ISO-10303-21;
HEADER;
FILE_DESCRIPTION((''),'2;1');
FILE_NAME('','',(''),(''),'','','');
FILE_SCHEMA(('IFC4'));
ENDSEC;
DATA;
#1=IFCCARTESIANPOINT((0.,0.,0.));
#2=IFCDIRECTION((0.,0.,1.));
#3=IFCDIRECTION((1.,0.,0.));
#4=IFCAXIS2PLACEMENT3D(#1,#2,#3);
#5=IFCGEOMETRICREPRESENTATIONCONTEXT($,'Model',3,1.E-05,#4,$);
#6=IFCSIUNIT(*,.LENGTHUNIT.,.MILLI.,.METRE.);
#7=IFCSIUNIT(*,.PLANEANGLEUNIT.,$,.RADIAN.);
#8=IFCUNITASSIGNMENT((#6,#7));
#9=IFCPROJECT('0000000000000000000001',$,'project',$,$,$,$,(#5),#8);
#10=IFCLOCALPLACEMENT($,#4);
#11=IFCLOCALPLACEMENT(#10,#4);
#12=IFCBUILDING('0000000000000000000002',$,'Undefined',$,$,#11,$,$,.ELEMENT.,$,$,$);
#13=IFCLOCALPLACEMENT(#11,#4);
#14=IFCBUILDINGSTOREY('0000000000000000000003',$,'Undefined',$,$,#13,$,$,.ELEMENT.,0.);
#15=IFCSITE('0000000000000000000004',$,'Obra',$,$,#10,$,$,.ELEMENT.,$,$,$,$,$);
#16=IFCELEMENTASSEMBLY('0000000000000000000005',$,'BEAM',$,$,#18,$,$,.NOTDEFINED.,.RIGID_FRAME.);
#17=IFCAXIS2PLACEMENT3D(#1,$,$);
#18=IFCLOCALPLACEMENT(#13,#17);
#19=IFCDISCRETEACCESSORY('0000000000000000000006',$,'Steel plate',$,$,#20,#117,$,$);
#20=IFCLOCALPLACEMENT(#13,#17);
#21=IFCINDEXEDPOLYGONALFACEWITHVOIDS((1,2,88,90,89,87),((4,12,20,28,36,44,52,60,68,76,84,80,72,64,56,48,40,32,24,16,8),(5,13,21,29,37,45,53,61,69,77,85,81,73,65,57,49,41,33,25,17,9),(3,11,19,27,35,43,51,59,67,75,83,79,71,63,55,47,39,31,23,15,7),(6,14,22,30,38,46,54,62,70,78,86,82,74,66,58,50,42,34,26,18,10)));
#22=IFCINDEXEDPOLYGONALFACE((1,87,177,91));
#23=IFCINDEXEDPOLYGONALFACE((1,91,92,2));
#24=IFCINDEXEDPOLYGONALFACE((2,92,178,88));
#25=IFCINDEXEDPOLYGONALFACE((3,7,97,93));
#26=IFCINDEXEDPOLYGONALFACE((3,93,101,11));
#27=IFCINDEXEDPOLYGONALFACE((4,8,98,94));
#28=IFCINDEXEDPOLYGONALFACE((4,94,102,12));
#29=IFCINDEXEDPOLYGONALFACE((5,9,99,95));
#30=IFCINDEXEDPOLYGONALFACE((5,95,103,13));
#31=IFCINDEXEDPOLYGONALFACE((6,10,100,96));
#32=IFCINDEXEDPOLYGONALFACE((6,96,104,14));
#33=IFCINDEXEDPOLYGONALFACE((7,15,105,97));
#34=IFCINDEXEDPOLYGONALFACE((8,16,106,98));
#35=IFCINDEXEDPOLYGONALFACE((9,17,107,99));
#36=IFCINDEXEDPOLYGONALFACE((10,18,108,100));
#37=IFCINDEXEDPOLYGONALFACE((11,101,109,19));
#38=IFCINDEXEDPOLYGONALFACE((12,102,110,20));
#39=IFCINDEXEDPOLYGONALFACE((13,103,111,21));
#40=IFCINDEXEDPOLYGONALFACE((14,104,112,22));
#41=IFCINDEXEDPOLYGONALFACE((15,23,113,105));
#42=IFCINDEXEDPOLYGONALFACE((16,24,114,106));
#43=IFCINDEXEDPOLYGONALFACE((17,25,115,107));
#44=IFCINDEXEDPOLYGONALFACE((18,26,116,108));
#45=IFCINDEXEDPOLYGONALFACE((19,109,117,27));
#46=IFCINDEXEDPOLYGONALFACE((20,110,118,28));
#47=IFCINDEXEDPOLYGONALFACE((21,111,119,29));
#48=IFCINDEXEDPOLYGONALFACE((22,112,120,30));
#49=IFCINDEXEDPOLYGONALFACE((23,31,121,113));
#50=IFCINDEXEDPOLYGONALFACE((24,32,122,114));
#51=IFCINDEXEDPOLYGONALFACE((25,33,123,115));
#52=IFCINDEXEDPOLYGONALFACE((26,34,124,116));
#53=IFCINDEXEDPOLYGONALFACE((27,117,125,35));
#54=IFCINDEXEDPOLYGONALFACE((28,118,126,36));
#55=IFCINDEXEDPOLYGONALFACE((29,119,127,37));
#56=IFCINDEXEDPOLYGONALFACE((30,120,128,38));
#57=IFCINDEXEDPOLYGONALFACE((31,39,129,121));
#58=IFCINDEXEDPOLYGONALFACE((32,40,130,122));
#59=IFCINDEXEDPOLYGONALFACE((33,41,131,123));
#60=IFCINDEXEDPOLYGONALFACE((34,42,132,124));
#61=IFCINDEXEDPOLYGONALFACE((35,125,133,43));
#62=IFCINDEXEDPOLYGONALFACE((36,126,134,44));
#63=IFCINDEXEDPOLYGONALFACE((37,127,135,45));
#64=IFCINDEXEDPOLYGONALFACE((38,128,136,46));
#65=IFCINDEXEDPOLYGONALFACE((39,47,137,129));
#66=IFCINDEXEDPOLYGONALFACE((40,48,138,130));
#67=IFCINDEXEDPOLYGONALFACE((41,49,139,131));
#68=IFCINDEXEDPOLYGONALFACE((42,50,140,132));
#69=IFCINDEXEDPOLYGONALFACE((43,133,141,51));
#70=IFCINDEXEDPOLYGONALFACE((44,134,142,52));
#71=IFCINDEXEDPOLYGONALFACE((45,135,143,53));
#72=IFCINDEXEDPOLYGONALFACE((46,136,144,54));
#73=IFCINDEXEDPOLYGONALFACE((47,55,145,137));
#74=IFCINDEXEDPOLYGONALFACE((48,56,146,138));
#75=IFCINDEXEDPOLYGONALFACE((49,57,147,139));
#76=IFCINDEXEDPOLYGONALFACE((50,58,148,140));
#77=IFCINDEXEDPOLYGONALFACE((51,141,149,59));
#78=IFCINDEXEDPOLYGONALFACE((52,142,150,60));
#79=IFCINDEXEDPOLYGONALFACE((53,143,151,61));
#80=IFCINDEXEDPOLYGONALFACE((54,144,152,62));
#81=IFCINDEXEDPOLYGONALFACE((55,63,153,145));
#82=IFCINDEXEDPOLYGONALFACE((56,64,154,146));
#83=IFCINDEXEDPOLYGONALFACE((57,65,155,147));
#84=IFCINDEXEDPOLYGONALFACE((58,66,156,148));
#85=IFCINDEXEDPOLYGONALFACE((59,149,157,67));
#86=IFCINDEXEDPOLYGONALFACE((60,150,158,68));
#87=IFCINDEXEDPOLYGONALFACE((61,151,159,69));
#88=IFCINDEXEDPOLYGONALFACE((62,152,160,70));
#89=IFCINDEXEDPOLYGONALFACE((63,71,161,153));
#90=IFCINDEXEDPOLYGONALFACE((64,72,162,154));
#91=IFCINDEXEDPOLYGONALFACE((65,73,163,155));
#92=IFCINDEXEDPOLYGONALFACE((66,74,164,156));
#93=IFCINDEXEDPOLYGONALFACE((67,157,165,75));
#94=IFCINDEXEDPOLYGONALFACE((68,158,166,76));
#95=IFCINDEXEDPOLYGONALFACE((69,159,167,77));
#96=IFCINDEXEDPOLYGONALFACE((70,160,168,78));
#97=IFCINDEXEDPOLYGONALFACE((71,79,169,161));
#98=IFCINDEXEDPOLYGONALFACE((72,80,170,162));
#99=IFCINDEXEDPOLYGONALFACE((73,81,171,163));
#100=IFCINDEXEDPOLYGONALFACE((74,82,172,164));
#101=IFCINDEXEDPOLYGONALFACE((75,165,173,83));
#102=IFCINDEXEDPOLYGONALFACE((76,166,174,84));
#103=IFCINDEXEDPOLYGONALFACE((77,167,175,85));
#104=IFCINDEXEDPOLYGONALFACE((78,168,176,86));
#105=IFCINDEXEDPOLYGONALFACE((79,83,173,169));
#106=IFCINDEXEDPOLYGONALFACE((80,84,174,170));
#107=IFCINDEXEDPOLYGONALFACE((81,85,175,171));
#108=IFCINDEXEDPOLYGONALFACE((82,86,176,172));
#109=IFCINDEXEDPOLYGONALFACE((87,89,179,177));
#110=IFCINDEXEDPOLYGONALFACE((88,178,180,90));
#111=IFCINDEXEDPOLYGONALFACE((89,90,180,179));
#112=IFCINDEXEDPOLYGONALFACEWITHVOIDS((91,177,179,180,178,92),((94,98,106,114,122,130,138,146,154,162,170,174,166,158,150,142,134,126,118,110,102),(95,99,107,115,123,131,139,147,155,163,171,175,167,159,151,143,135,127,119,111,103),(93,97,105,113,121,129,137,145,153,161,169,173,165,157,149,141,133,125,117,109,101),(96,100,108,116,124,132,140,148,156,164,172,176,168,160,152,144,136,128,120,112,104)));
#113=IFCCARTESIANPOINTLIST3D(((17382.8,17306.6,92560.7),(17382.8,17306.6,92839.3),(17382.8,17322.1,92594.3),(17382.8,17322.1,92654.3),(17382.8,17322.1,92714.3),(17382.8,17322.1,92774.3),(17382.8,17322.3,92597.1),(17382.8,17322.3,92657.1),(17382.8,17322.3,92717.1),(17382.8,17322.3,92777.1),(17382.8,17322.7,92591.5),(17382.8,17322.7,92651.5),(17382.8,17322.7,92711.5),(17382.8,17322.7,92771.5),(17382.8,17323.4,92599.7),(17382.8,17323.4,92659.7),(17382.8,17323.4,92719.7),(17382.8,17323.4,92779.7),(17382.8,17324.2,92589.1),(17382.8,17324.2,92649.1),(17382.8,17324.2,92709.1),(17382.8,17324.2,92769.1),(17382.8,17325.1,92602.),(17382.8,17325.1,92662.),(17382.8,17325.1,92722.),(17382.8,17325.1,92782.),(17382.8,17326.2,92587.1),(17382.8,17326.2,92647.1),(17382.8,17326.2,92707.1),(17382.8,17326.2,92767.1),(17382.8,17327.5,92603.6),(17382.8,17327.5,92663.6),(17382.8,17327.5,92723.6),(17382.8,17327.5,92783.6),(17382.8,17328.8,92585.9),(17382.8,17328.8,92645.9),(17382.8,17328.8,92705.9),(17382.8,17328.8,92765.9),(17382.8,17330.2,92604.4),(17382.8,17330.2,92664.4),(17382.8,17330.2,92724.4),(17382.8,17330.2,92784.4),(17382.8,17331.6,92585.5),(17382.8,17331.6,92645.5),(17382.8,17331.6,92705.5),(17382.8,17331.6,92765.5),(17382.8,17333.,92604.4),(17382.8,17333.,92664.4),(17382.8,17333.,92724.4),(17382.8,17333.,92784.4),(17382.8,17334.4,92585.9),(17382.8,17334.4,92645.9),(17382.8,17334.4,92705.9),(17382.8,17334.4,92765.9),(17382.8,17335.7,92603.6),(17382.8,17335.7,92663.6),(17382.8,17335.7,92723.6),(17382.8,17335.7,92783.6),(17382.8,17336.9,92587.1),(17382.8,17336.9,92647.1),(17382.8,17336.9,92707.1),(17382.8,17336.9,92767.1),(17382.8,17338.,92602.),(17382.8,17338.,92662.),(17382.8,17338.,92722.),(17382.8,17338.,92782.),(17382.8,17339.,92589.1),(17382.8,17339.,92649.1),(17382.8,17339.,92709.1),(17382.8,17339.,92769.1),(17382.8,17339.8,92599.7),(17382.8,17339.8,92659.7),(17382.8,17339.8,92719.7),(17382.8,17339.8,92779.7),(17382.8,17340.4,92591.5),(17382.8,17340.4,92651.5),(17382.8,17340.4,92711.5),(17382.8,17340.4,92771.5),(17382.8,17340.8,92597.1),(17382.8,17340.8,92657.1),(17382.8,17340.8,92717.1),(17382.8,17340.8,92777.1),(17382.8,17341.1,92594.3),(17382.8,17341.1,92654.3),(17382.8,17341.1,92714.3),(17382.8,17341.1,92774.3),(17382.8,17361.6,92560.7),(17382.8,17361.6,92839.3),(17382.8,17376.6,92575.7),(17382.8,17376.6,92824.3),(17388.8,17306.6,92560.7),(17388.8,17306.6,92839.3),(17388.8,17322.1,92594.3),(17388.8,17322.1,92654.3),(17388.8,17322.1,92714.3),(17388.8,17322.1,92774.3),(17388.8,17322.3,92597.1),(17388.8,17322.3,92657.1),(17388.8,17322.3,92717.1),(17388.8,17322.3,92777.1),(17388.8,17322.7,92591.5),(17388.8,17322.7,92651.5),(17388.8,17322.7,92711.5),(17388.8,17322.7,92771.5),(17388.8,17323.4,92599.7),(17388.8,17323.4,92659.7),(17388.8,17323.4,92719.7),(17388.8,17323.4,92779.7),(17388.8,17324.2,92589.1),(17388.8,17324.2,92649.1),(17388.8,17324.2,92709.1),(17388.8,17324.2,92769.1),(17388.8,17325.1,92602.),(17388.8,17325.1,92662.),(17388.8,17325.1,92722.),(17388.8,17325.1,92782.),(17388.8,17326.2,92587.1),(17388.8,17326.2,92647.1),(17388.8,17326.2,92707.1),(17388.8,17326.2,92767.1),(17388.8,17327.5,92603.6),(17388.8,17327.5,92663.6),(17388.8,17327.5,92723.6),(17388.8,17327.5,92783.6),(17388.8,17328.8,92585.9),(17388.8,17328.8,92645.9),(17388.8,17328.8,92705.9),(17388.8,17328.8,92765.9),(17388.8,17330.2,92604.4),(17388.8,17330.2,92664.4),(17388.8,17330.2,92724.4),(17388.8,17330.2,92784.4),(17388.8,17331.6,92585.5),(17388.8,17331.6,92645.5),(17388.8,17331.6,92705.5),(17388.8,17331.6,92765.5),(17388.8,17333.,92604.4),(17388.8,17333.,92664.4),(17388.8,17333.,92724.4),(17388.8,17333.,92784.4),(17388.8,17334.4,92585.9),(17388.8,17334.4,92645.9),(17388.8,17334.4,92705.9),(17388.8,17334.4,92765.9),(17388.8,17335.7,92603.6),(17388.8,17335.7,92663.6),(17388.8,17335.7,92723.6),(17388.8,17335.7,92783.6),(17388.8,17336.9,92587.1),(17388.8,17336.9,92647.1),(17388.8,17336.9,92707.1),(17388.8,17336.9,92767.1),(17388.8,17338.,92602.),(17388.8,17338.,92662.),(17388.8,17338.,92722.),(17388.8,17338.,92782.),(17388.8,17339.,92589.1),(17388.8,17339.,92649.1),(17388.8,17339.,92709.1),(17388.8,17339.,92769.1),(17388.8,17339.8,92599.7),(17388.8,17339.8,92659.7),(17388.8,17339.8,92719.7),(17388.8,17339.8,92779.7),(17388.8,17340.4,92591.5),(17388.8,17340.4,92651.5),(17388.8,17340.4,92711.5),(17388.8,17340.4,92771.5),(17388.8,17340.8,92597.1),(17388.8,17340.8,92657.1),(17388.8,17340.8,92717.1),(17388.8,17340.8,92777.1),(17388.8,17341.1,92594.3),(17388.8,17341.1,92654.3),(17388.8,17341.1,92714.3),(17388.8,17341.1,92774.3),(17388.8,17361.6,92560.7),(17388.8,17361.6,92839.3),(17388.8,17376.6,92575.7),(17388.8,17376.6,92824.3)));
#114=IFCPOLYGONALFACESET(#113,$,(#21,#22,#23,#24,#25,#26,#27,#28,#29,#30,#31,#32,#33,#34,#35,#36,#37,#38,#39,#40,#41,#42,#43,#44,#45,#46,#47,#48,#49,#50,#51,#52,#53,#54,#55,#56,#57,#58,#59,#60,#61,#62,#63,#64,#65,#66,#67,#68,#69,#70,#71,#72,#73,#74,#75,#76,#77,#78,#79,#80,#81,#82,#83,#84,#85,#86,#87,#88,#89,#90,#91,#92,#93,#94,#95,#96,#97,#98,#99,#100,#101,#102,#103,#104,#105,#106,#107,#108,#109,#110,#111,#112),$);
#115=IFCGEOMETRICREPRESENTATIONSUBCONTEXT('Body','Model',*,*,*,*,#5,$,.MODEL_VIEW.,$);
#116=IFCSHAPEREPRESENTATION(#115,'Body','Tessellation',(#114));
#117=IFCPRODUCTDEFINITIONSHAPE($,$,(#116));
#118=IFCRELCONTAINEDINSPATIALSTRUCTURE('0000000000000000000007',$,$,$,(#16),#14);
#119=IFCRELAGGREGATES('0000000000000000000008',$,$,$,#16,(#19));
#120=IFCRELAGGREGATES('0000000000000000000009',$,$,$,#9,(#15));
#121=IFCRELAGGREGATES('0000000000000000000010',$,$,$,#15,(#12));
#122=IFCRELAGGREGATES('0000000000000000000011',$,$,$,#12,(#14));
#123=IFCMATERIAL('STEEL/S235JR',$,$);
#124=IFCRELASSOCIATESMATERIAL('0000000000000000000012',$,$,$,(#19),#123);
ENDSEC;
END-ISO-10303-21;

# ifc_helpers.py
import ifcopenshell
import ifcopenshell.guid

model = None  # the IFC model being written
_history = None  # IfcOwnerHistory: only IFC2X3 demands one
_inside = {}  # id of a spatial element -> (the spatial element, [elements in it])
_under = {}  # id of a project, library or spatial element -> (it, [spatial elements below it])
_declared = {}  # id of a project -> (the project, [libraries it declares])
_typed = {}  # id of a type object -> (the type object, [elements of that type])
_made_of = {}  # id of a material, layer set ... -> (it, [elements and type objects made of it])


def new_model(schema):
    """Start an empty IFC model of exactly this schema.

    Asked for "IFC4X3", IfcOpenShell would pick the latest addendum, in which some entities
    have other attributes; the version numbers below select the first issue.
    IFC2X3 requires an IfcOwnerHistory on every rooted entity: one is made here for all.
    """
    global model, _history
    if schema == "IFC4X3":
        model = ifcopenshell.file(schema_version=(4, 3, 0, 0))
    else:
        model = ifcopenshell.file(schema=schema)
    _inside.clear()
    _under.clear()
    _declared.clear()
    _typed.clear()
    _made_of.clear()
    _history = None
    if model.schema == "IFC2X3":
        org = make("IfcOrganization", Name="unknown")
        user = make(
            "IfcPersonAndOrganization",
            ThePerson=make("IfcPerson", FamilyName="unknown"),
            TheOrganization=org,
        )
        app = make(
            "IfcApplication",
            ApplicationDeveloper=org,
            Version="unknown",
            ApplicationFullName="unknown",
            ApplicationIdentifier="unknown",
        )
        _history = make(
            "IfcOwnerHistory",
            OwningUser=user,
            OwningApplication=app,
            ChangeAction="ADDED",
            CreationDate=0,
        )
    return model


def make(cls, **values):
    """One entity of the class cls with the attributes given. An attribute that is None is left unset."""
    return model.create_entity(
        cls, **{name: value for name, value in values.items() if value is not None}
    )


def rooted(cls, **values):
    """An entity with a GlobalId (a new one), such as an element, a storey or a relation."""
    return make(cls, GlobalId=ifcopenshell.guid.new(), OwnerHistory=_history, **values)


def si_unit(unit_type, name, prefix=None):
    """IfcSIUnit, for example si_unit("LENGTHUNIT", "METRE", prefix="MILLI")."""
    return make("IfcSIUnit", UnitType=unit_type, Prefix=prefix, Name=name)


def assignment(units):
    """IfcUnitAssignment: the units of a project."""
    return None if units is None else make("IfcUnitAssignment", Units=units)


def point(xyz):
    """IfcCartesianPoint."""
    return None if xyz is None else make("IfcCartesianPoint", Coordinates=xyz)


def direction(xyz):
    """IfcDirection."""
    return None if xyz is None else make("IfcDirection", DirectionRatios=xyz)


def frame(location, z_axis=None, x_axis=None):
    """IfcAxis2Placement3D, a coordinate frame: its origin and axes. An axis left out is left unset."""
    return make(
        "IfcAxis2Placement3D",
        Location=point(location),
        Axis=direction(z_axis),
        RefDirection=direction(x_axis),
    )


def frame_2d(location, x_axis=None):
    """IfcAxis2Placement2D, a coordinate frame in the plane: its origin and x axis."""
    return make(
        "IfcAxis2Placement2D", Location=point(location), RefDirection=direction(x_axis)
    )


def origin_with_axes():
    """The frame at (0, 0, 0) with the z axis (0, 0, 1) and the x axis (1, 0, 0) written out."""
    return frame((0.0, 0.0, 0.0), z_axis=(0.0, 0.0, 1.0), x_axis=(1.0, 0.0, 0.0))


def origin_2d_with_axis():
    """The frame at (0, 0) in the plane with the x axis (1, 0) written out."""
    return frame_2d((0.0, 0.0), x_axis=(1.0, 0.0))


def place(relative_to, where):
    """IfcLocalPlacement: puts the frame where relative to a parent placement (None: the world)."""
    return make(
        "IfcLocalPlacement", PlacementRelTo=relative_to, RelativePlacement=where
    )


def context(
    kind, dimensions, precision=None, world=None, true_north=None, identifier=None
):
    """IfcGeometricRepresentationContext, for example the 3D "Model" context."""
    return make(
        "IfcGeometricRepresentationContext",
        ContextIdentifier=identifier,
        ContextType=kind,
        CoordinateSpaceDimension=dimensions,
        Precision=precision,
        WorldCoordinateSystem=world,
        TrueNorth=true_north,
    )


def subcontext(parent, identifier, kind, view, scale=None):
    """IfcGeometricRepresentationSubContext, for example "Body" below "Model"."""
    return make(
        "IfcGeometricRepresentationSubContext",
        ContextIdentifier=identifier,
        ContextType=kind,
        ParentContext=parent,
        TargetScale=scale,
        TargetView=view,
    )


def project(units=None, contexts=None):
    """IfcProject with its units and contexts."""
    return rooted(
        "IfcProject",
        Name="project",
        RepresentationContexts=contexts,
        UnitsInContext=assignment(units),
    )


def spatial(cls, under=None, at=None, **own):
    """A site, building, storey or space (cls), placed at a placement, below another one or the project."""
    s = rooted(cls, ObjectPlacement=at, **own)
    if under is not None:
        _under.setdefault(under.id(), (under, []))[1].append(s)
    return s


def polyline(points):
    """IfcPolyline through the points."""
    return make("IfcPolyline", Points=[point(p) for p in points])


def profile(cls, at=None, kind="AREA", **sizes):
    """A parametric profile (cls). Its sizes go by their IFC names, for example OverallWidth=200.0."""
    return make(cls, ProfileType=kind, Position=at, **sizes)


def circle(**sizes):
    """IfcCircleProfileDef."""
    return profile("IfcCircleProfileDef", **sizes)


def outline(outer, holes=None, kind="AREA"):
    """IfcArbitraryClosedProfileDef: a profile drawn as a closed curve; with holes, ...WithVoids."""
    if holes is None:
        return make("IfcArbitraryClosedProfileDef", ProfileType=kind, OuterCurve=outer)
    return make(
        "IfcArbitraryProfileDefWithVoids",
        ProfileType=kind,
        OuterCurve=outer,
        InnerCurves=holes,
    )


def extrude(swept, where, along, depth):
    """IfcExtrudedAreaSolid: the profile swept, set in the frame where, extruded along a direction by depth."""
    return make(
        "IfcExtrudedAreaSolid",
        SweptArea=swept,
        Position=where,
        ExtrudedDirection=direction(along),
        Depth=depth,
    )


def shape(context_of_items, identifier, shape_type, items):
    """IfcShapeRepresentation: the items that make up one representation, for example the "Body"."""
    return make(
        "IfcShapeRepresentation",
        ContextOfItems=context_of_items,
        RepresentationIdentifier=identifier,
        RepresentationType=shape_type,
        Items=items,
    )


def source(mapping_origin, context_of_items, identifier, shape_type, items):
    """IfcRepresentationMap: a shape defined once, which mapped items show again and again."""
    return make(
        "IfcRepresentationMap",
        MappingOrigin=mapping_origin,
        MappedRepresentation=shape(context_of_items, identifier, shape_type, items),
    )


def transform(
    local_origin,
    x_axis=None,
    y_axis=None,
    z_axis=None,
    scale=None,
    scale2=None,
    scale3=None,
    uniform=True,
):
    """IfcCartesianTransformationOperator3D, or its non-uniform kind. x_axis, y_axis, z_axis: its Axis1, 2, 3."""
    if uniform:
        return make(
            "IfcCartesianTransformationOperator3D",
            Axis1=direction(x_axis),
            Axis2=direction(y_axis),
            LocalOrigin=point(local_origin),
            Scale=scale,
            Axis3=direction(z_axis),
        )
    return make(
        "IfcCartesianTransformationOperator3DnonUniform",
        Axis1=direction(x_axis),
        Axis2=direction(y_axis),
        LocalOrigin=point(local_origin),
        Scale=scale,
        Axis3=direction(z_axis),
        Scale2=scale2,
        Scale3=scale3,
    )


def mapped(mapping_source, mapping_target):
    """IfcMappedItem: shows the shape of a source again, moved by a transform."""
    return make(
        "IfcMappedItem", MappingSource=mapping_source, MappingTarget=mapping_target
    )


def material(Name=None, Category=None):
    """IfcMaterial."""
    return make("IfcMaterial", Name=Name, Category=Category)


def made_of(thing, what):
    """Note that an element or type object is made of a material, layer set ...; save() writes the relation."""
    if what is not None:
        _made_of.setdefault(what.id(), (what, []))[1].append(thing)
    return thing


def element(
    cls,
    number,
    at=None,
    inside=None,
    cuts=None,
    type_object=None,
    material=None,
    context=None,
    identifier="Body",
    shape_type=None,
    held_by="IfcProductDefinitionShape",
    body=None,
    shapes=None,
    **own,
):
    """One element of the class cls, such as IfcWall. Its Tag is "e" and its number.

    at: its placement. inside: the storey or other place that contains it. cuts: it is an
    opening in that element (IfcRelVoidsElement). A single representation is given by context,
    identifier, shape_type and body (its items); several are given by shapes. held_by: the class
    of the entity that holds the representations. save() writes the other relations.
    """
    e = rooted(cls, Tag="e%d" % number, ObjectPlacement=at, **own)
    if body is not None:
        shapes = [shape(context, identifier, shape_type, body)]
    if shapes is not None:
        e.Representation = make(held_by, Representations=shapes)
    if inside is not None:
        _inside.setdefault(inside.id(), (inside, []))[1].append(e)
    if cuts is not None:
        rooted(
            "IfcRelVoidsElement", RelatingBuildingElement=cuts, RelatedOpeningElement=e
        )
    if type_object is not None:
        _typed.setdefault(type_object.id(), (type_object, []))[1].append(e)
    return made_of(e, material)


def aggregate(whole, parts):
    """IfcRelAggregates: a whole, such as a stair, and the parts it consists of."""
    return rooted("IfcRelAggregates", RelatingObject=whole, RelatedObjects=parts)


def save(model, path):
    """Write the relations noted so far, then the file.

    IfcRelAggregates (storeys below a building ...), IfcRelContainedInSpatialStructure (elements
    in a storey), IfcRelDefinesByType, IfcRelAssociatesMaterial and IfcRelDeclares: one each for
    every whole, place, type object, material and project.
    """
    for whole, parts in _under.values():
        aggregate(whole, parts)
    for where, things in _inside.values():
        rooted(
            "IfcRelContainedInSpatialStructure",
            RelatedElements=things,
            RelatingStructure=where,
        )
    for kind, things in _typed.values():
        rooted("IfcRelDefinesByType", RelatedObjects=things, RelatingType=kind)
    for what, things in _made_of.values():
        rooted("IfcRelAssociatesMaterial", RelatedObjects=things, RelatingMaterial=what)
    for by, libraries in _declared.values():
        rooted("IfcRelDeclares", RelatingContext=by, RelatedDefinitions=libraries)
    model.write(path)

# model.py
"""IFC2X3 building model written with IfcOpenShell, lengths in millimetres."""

from ifc_helpers import new_model, si_unit, frame, origin_with_axes, origin_2d_with_axis, place, context, subcontext, project, spatial, polyline, circle, outline, extrude, source, transform, mapped, material, element, aggregate, save


model = new_model("IFC2X3")

# Units and contexts
model_context = context("Model", 3, precision=1e-05, world=origin_with_axes())
body_context = subcontext(model_context, "Body", "Model", "MODEL_VIEW")
ifc_project = project(units=[si_unit("LENGTHUNIT", "METRE", prefix="MILLI"), si_unit("PLANEANGLEUNIT", "RADIAN")], contexts=[model_context])

# Site, building, storey
site_placement = place(None, origin_with_axes())
site = spatial("IfcSite", under=ifc_project, at=site_placement, Name="Obra", CompositionType="ELEMENT")
building_placement = place(site_placement, origin_with_axes())
building = spatial("IfcBuilding", under=site, at=building_placement, Name="Undefined", CompositionType="ELEMENT")
storey_placement = place(building_placement, origin_with_axes())
storey = spatial("IfcBuildingStorey", under=building, at=storey_placement, Name="Undefined", CompositionType="ELEMENT", Elevation=0.0)

# Element assembly, discrete accessory, opening
assembly_1_placement = place(storey_placement, origin_with_axes())
assembly_1 = element("IfcElementAssembly", 1, at=assembly_1_placement, inside=storey, Name="BEAM", AssemblyPlace="NOTDEFINED", PredefinedType="RIGID_FRAME")
ifc_material_1 = material(Name="STEEL/S235JR")
shared_shape_1 = source(origin_with_axes(), body_context, "Body", "SweptSolid", [
    extrude(circle(Radius=9.5, at=origin_2d_with_axis()), frame((0.0, -9.8, 0.0), z_axis=(0.0, 1.0, 0.0), x_axis=(1.0, 0.0, 0.0)), (0.0, 0.0, 1.0), 6.2),
])
discrete_accessory_1_placement = place(assembly_1_placement, frame((17385.8, 17306.6, 92560.7), z_axis=(1.0, 0.0, 0.0), x_axis=(0.0, 1.0, 0.0)))
discrete_accessory_1 = element("IfcDiscreteAccessory", 2, at=discrete_accessory_1_placement, material=ifc_material_1, Name="Steel plate", context=body_context, shape_type="SweptSolid", body=[
    extrude(outline(polyline([(0.0, 0.0), (55.0, 0.0), (70.0, 15.0), (70.0, 263.6), (55.0, 278.6), (0.0, 278.6), (0.0, 0.0)])), frame((0.0, 0.0, -3.0), z_axis=(0.0, 0.0, 1.0), x_axis=(1.0, 0.0, 0.0)), (0.0, 0.0, 1.0), 6.0),
])
opening_1_placement = place(assembly_1_placement, frame((17392.6, 17366.6, 92850.0), z_axis=(0.0, -1.0, 0.0), x_axis=(0.0, 0.0, -1.0)))
element("IfcOpeningElement", 3, at=opening_1_placement, cuts=discrete_accessory_1, ObjectType="Opening", context=body_context, shape_type="MappedRepresentation", body=[
    mapped(shared_shape_1, transform((75.0, 0.0, 35.0))),
    mapped(shared_shape_1, transform((135.0, 0.0, 35.0))),
    mapped(shared_shape_1, transform((195.0, 0.0, 35.0))),
    mapped(shared_shape_1, transform((255.0, 0.0, 35.0))),
])

aggregate(assembly_1, [discrete_accessory_1])

save(model, "model.ifc")
